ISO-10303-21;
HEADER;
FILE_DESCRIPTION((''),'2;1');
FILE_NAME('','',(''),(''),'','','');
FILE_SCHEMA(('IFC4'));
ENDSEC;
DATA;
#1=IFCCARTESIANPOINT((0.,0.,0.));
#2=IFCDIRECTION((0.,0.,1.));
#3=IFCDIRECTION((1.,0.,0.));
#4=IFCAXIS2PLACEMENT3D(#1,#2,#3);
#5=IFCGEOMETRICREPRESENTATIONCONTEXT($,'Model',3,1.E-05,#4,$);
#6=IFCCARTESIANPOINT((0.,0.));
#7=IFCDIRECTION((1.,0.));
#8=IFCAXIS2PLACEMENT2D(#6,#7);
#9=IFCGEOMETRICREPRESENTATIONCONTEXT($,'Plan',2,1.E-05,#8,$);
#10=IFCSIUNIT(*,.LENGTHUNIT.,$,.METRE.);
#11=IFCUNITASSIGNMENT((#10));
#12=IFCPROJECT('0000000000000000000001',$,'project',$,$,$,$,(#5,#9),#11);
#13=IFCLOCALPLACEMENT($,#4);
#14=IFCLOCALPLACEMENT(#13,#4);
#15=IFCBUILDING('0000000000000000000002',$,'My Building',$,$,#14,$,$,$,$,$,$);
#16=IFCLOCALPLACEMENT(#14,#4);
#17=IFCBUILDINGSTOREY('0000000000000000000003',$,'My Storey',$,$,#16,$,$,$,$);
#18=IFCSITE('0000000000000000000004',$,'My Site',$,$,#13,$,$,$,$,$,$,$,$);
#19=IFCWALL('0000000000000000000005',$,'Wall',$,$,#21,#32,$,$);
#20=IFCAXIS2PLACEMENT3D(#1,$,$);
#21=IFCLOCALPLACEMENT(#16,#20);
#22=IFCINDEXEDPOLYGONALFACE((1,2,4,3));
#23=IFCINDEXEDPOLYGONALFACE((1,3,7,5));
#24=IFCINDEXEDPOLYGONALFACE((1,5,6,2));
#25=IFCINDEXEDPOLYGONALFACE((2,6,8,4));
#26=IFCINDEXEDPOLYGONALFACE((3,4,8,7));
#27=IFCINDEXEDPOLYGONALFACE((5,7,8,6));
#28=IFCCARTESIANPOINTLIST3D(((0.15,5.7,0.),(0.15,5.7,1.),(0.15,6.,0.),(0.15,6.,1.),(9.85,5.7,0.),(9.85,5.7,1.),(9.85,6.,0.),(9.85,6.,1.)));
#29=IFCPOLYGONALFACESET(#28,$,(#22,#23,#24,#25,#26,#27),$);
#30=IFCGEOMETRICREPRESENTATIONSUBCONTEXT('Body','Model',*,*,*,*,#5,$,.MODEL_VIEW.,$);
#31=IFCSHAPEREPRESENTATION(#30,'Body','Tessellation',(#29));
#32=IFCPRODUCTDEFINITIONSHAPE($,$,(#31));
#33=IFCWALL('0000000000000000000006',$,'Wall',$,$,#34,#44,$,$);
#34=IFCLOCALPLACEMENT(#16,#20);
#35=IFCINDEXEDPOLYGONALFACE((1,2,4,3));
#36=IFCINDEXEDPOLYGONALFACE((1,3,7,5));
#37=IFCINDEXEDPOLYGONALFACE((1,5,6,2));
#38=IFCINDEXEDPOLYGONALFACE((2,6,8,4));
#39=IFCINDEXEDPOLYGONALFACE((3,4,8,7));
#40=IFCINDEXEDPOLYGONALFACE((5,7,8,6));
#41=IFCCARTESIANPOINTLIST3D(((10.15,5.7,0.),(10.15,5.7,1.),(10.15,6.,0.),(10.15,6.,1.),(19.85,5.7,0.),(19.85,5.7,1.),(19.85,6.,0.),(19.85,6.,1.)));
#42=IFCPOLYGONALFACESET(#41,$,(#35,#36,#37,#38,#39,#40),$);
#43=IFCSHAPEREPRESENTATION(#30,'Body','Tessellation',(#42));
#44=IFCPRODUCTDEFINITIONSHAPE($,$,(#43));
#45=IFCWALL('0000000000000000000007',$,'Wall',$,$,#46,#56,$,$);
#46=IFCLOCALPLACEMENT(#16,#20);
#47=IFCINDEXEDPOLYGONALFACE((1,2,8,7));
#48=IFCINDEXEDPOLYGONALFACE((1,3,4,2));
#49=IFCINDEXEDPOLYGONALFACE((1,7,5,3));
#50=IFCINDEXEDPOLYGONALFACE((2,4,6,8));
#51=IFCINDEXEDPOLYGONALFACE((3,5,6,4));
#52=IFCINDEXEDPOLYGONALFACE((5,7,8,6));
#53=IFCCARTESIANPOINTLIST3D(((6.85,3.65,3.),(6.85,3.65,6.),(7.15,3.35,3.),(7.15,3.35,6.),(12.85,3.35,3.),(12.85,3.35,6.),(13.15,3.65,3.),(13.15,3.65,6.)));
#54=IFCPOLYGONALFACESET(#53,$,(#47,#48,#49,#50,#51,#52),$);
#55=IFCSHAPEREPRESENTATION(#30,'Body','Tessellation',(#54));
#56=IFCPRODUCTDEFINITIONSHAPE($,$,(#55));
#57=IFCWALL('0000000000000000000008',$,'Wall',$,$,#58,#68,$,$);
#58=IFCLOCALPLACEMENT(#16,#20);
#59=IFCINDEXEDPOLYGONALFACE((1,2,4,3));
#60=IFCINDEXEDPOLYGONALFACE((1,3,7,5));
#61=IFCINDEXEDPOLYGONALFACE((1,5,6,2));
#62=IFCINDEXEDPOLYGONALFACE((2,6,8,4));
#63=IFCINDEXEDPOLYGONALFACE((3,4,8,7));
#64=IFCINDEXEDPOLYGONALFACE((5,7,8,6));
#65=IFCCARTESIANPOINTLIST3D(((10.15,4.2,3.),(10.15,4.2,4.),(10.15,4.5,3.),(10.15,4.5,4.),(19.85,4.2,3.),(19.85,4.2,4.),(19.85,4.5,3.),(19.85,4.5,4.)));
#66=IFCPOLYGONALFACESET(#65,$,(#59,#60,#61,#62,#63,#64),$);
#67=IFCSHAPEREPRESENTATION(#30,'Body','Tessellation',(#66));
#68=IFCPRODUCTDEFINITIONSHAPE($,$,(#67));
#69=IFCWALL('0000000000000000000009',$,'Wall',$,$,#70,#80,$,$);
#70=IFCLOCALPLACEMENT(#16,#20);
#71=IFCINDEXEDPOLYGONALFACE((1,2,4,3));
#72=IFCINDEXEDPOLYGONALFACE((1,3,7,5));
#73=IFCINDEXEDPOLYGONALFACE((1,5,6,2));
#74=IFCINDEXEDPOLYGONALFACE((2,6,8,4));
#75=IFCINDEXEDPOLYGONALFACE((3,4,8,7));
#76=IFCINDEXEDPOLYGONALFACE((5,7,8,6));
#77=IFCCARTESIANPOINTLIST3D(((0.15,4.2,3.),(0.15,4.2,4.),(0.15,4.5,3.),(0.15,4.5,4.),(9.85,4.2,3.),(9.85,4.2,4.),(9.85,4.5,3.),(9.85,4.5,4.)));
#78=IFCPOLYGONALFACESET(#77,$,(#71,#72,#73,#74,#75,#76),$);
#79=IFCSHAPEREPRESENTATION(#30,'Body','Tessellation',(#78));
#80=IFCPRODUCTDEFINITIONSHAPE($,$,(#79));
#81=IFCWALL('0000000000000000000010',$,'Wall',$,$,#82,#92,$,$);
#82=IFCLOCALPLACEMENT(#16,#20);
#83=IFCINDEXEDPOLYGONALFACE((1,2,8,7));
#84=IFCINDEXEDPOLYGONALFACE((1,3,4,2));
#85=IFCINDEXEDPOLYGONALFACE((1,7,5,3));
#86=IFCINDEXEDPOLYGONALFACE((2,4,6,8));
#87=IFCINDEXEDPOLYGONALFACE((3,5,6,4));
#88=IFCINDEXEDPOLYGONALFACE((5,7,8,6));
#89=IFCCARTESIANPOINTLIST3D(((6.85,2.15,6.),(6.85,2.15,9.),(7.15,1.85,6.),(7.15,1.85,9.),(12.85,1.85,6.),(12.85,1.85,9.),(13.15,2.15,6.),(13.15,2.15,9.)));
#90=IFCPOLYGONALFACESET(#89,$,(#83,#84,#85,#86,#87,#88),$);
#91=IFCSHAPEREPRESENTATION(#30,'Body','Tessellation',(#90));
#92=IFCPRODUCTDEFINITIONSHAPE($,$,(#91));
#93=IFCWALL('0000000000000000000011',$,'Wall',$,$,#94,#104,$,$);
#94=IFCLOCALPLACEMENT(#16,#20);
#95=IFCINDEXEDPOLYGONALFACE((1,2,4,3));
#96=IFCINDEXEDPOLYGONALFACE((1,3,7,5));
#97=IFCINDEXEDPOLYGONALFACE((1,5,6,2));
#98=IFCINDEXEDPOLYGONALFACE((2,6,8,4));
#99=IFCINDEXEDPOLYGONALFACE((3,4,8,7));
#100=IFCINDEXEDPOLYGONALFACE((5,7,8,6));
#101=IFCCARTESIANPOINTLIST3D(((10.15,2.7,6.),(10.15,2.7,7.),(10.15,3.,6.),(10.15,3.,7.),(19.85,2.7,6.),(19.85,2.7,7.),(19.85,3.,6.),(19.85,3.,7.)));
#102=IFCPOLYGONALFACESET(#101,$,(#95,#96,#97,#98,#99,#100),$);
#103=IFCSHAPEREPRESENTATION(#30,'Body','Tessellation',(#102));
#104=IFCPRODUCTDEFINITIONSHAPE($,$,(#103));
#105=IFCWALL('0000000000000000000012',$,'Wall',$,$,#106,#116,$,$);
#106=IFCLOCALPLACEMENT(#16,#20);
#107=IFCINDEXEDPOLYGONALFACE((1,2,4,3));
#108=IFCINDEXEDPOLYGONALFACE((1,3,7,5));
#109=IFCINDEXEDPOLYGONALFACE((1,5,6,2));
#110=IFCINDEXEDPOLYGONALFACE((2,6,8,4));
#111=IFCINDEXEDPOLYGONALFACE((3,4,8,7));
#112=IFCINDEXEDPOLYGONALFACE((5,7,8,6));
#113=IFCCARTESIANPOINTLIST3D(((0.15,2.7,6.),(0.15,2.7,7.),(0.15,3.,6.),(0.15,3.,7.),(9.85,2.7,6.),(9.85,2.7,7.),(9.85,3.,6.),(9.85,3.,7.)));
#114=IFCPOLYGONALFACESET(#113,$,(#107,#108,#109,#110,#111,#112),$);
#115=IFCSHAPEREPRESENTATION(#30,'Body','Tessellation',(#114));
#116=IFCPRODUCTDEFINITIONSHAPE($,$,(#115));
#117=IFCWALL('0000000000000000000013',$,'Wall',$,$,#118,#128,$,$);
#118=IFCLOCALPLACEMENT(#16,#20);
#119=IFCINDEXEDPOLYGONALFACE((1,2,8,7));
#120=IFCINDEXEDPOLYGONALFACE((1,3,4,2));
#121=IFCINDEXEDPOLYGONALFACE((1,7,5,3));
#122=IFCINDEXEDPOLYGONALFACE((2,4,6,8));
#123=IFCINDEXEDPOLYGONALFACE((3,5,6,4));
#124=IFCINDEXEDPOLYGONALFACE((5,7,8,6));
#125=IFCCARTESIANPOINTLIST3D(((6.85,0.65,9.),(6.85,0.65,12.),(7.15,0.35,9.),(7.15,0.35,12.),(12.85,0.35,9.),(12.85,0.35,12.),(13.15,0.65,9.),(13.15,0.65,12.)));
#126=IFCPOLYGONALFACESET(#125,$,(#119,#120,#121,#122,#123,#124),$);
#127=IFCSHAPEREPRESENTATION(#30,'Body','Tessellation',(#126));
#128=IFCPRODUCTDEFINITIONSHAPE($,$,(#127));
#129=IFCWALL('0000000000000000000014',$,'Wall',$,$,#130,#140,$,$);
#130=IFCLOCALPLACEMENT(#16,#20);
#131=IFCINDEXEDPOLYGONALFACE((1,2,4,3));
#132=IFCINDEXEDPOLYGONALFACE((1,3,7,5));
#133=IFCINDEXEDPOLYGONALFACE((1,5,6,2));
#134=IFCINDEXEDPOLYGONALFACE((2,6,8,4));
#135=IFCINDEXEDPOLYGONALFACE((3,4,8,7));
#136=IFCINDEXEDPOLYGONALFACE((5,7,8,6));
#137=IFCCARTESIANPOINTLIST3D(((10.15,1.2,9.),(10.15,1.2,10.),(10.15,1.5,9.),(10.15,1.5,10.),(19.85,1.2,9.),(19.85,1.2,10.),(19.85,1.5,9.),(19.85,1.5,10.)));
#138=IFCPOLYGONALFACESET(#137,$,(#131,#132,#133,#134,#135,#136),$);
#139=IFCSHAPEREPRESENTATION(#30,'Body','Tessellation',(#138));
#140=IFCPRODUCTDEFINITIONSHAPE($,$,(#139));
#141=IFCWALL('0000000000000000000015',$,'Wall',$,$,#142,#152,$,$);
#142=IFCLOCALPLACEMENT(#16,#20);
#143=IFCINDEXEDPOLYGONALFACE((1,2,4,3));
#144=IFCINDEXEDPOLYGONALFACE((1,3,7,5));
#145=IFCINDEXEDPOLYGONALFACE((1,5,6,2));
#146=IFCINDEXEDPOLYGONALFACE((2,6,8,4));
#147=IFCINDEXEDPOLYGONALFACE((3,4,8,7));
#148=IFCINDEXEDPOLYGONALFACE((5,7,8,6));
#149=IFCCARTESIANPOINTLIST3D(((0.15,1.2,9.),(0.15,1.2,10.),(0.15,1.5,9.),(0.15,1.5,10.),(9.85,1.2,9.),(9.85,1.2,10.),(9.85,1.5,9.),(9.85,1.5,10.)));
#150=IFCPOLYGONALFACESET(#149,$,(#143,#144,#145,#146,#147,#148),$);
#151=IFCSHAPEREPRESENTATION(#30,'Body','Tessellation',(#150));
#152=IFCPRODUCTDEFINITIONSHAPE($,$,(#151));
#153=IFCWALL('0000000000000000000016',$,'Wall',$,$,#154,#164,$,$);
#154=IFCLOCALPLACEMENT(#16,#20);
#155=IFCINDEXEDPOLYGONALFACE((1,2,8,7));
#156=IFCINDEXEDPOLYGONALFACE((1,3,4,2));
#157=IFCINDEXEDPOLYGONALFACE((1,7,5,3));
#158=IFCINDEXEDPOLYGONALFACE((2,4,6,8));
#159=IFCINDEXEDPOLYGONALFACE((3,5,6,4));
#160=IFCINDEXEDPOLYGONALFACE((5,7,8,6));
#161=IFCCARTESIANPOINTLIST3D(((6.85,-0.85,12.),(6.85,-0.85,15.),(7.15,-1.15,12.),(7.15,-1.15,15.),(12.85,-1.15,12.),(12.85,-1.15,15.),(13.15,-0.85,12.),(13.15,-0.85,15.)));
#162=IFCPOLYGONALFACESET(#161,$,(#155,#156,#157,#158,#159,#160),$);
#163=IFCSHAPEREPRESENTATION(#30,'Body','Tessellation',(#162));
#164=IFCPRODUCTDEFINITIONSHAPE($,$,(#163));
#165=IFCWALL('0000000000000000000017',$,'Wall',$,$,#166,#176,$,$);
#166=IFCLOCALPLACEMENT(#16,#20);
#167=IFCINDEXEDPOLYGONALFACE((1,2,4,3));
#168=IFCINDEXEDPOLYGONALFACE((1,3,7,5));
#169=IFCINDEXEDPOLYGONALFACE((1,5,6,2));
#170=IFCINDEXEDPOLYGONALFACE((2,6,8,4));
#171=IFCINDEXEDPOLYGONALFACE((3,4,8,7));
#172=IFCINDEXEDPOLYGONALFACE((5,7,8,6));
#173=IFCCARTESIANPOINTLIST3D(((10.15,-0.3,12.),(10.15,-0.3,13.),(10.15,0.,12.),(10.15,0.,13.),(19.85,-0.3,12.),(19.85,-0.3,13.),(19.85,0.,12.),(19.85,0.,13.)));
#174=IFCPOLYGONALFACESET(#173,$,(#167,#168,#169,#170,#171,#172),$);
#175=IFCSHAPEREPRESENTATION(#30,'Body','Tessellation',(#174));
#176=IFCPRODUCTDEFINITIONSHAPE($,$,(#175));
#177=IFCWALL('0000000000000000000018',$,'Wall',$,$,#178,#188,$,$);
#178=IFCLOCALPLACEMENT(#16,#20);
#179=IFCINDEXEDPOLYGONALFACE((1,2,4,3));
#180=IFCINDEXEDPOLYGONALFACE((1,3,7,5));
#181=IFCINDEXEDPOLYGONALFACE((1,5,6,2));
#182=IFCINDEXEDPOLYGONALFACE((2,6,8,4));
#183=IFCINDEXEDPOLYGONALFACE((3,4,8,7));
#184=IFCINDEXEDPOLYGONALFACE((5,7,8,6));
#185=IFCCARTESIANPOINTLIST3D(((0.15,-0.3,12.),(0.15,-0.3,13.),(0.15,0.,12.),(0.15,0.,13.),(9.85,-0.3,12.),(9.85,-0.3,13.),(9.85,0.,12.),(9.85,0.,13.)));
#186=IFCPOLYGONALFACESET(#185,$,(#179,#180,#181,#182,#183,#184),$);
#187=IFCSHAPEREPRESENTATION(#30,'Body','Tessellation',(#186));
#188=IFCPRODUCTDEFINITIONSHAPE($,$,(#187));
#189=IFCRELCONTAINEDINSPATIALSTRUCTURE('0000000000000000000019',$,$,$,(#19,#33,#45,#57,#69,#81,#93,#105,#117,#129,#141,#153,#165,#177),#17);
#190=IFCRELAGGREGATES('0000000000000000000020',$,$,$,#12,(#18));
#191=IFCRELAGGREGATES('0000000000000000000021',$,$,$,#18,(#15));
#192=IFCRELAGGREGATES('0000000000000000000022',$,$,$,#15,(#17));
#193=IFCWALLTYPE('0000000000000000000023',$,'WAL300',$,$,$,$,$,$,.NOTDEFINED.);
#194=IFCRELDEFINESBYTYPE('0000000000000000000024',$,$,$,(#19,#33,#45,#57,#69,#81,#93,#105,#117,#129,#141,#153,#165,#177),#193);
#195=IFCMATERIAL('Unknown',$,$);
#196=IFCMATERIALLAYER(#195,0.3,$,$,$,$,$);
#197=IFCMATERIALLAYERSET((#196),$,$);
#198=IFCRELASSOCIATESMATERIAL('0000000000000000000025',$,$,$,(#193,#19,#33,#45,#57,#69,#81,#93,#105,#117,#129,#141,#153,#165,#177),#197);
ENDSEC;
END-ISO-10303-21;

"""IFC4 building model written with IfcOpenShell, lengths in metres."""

from ifc_helpers import new_model, si_unit, frame, origin_with_axes, origin_2d_with_axis, place, context, subcontext, project, spatial, line, indexed_curve, outline, extrude, material, layer, layer_set, layer_usage, type_object, element, save


model = new_model("IFC4")

# Units and contexts
model_context = context("Model", 3, precision=1e-05, world=origin_with_axes())
plan_context = context("Plan", 2, precision=1e-05, world=origin_2d_with_axis())
body_context = subcontext(model_context, "Body", "Model", "MODEL_VIEW")
ifc_project = project(units=[si_unit("LENGTHUNIT", "METRE")], contexts=[model_context, plan_context])

# Site, building, storey
site_placement = place(None, origin_with_axes())
site = spatial("IfcSite", under=ifc_project, at=site_placement, Name="My Site")
building_placement = place(site_placement, origin_with_axes())
building = spatial("IfcBuilding", under=site, at=building_placement, Name="My Building")
storey_placement = place(building_placement, origin_with_axes())
storey = spatial("IfcBuildingStorey", under=building, at=storey_placement, Name="My Storey")

# Walls
ifc_material = material(Name="Unknown")
ifc_layer = layer(ifc_material, 0.3)
ifc_layer_set = layer_set([ifc_layer])
wall_type = type_object("IfcWallType", Name="WAL300", PredefinedType="NOTDEFINED", material=ifc_layer_set)
ifc_layer_usage_1 = layer_usage(ifc_layer_set, "AXIS2", "POSITIVE", -0.3)
wall_1_placement = place(storey_placement, frame((0.15, 6.0, 0.0), z_axis=(0.0, 0.0, 1.0), x_axis=(1.0, 0.0, 0.0)))
element("IfcWall", 1, at=wall_1_placement, inside=storey, type_object=wall_type, material=ifc_layer_usage_1, Name="Wall", context=body_context, shape_type="SweptSolid", body=[
    extrude(outline(indexed_curve([(0.0, -0.3), (0.0, 0.0), (9.7, 0.0), (9.7, -0.3)], segments=[line(1, 2, 3, 4, 1)])), origin_with_axes(), (0.0, 0.0, 1.0), 1.0),
])
ifc_layer_usage_2 = layer_usage(ifc_layer_set, "AXIS2", "POSITIVE", -0.3)
wall_2_placement = place(storey_placement, frame((10.15, 6.0, 0.0), z_axis=(0.0, 0.0, 1.0), x_axis=(1.0, 0.0, 0.0)))
element("IfcWall", 2, at=wall_2_placement, inside=storey, type_object=wall_type, material=ifc_layer_usage_2, Name="Wall", context=body_context, shape_type="SweptSolid", body=[
    extrude(outline(indexed_curve([(0.0, -0.3), (0.0, 0.0), (9.7, 0.0), (9.7, -0.3)], segments=[line(1, 2, 3, 4, 1)])), origin_with_axes(), (0.0, 0.0, 1.0), 1.0),
])
ifc_layer_usage_3 = layer_usage(ifc_layer_set, "AXIS2", "POSITIVE", -0.15)
wall_3_placement = place(storey_placement, frame((7.0, 3.5, 3.0), z_axis=(0.0, 0.0, 1.0), x_axis=(1.0, 0.0, 0.0)))
element("IfcWall", 3, at=wall_3_placement, inside=storey, type_object=wall_type, material=ifc_layer_usage_3, Name="Wall", context=body_context, shape_type="SweptSolid", body=[
    extrude(outline(indexed_curve([(0.15, -0.15), (-0.15, 0.15), (6.15, 0.15), (5.85, -0.15)], segments=[line(1, 2, 3, 4, 1)])), origin_with_axes(), (0.0, 0.0, 1.0), 3.0),
])
ifc_layer_usage_4 = layer_usage(ifc_layer_set, "AXIS2", "POSITIVE", -0.3)
wall_4_placement = place(storey_placement, frame((10.15, 4.5, 3.0), z_axis=(0.0, 0.0, 1.0), x_axis=(1.0, 0.0, 0.0)))
element("IfcWall", 4, at=wall_4_placement, inside=storey, type_object=wall_type, material=ifc_layer_usage_4, Name="Wall", context=body_context, shape_type="SweptSolid", body=[
    extrude(outline(indexed_curve([(0.0, -0.3), (0.0, 0.0), (9.7, 0.0), (9.7, -0.3)], segments=[line(1, 2, 3, 4, 1)])), origin_with_axes(), (0.0, 0.0, 1.0), 1.0),
])
ifc_layer_usage_5 = layer_usage(ifc_layer_set, "AXIS2", "POSITIVE", -0.3)
wall_5_placement = place(storey_placement, frame((0.15, 4.5, 3.0), z_axis=(0.0, 0.0, 1.0), x_axis=(1.0, 0.0, 0.0)))
element("IfcWall", 5, at=wall_5_placement, inside=storey, type_object=wall_type, material=ifc_layer_usage_5, Name="Wall", context=body_context, shape_type="SweptSolid", body=[
    extrude(outline(indexed_curve([(0.0, -0.3), (0.0, 0.0), (9.7, 0.0), (9.7, -0.3)], segments=[line(1, 2, 3, 4, 1)])), origin_with_axes(), (0.0, 0.0, 1.0), 1.0),
])
ifc_layer_usage_6 = layer_usage(ifc_layer_set, "AXIS2", "POSITIVE", -0.15)
wall_6_placement = place(storey_placement, frame((7.0, 2.0, 6.0), z_axis=(0.0, 0.0, 1.0), x_axis=(1.0, 0.0, 0.0)))
element("IfcWall", 6, at=wall_6_placement, inside=storey, type_object=wall_type, material=ifc_layer_usage_6, Name="Wall", context=body_context, shape_type="SweptSolid", body=[
    extrude(outline(indexed_curve([(0.15, -0.15), (-0.15, 0.15), (6.15, 0.15), (5.85, -0.15)], segments=[line(1, 2, 3, 4, 1)])), origin_with_axes(), (0.0, 0.0, 1.0), 3.0),
])
ifc_layer_usage_7 = layer_usage(ifc_layer_set, "AXIS2", "POSITIVE", -0.3)
wall_7_placement = place(storey_placement, frame((10.15, 3.0, 6.0), z_axis=(0.0, 0.0, 1.0), x_axis=(1.0, 0.0, 0.0)))
element("IfcWall", 7, at=wall_7_placement, inside=storey, type_object=wall_type, material=ifc_layer_usage_7, Name="Wall", context=body_context, shape_type="SweptSolid", body=[
    extrude(outline(indexed_curve([(0.0, -0.3), (0.0, 0.0), (9.7, 0.0), (9.7, -0.3)], segments=[line(1, 2, 3, 4, 1)])), origin_with_axes(), (0.0, 0.0, 1.0), 1.0),
])
ifc_layer_usage_8 = layer_usage(ifc_layer_set, "AXIS2", "POSITIVE", -0.3)
wall_8_placement = place(storey_placement, frame((0.15, 3.0, 6.0), z_axis=(0.0, 0.0, 1.0), x_axis=(1.0, 0.0, 0.0)))
element("IfcWall", 8, at=wall_8_placement, inside=storey, type_object=wall_type, material=ifc_layer_usage_8, Name="Wall", context=body_context, shape_type="SweptSolid", body=[
    extrude(outline(indexed_curve([(0.0, -0.3), (0.0, 0.0), (9.7, 0.0), (9.7, -0.3)], segments=[line(1, 2, 3, 4, 1)])), origin_with_axes(), (0.0, 0.0, 1.0), 1.0),
])
ifc_layer_usage_9 = layer_usage(ifc_layer_set, "AXIS2", "POSITIVE", -0.15)
wall_9_placement = place(storey_placement, frame((7.0, 0.5, 9.0), z_axis=(0.0, 0.0, 1.0), x_axis=(1.0, 0.0, 0.0)))
element("IfcWall", 9, at=wall_9_placement, inside=storey, type_object=wall_type, material=ifc_layer_usage_9, Name="Wall", context=body_context, shape_type="SweptSolid", body=[
    extrude(outline(indexed_curve([(0.15, -0.15), (-0.15, 0.15), (6.15, 0.15), (5.85, -0.15)], segments=[line(1, 2, 3, 4, 1)])), origin_with_axes(), (0.0, 0.0, 1.0), 3.0),
])
ifc_layer_usage_10 = layer_usage(ifc_layer_set, "AXIS2", "POSITIVE", -0.3)
wall_10_placement = place(storey_placement, frame((10.15, 1.5, 9.0), z_axis=(0.0, 0.0, 1.0), x_axis=(1.0, 0.0, 0.0)))
element("IfcWall", 10, at=wall_10_placement, inside=storey, type_object=wall_type, material=ifc_layer_usage_10, Name="Wall", context=body_context, shape_type="SweptSolid", body=[
    extrude(outline(indexed_curve([(0.0, -0.3), (0.0, 0.0), (9.7, 0.0), (9.7, -0.3)], segments=[line(1, 2, 3, 4, 1)])), origin_with_axes(), (0.0, 0.0, 1.0), 1.0),
])
ifc_layer_usage_11 = layer_usage(ifc_layer_set, "AXIS2", "POSITIVE", -0.3)
wall_11_placement = place(storey_placement, frame((0.15, 1.5, 9.0), z_axis=(0.0, 0.0, 1.0), x_axis=(1.0, 0.0, 0.0)))
element("IfcWall", 11, at=wall_11_placement, inside=storey, type_object=wall_type, material=ifc_layer_usage_11, Name="Wall", context=body_context, shape_type="SweptSolid", body=[
    extrude(outline(indexed_curve([(0.0, -0.3), (0.0, 0.0), (9.7, 0.0), (9.7, -0.3)], segments=[line(1, 2, 3, 4, 1)])), origin_with_axes(), (0.0, 0.0, 1.0), 1.0),
])
ifc_layer_usage_12 = layer_usage(ifc_layer_set, "AXIS2", "POSITIVE", -0.15)
wall_12_placement = place(storey_placement, frame((7.0, -1.0, 12.0), z_axis=(0.0, 0.0, 1.0), x_axis=(1.0, 0.0, 0.0)))
element("IfcWall", 12, at=wall_12_placement, inside=storey, type_object=wall_type, material=ifc_layer_usage_12, Name="Wall", context=body_context, shape_type="SweptSolid", body=[
    extrude(outline(indexed_curve([(0.15, -0.15), (-0.15, 0.15), (6.15, 0.15), (5.85, -0.15)], segments=[line(1, 2, 3, 4, 1)])), origin_with_axes(), (0.0, 0.0, 1.0), 3.0),
])
ifc_layer_usage_13 = layer_usage(ifc_layer_set, "AXIS2", "POSITIVE", -0.3)
wall_13_placement = place(storey_placement, frame((10.15, 0.0, 12.0), z_axis=(0.0, 0.0, 1.0), x_axis=(1.0, 0.0, 0.0)))
element("IfcWall", 13, at=wall_13_placement, inside=storey, type_object=wall_type, material=ifc_layer_usage_13, Name="Wall", context=body_context, shape_type="SweptSolid", body=[
    extrude(outline(indexed_curve([(0.0, -0.3), (0.0, 0.0), (9.7, 0.0), (9.7, -0.3)], segments=[line(1, 2, 3, 4, 1)])), origin_with_axes(), (0.0, 0.0, 1.0), 1.0),
])
ifc_layer_usage_14 = layer_usage(ifc_layer_set, "AXIS2", "POSITIVE", -0.3)
wall_14_placement = place(storey_placement, frame((0.15, 0.0, 12.0), z_axis=(0.0, 0.0, 1.0), x_axis=(1.0, 0.0, 0.0)))
element("IfcWall", 14, at=wall_14_placement, inside=storey, type_object=wall_type, material=ifc_layer_usage_14, Name="Wall", context=body_context, shape_type="SweptSolid", body=[
    extrude(outline(indexed_curve([(0.0, -0.3), (0.0, 0.0), (9.7, 0.0), (9.7, -0.3)], segments=[line(1, 2, 3, 4, 1)])), origin_with_axes(), (0.0, 0.0, 1.0), 1.0),
])

save(model, "model.ifc")
